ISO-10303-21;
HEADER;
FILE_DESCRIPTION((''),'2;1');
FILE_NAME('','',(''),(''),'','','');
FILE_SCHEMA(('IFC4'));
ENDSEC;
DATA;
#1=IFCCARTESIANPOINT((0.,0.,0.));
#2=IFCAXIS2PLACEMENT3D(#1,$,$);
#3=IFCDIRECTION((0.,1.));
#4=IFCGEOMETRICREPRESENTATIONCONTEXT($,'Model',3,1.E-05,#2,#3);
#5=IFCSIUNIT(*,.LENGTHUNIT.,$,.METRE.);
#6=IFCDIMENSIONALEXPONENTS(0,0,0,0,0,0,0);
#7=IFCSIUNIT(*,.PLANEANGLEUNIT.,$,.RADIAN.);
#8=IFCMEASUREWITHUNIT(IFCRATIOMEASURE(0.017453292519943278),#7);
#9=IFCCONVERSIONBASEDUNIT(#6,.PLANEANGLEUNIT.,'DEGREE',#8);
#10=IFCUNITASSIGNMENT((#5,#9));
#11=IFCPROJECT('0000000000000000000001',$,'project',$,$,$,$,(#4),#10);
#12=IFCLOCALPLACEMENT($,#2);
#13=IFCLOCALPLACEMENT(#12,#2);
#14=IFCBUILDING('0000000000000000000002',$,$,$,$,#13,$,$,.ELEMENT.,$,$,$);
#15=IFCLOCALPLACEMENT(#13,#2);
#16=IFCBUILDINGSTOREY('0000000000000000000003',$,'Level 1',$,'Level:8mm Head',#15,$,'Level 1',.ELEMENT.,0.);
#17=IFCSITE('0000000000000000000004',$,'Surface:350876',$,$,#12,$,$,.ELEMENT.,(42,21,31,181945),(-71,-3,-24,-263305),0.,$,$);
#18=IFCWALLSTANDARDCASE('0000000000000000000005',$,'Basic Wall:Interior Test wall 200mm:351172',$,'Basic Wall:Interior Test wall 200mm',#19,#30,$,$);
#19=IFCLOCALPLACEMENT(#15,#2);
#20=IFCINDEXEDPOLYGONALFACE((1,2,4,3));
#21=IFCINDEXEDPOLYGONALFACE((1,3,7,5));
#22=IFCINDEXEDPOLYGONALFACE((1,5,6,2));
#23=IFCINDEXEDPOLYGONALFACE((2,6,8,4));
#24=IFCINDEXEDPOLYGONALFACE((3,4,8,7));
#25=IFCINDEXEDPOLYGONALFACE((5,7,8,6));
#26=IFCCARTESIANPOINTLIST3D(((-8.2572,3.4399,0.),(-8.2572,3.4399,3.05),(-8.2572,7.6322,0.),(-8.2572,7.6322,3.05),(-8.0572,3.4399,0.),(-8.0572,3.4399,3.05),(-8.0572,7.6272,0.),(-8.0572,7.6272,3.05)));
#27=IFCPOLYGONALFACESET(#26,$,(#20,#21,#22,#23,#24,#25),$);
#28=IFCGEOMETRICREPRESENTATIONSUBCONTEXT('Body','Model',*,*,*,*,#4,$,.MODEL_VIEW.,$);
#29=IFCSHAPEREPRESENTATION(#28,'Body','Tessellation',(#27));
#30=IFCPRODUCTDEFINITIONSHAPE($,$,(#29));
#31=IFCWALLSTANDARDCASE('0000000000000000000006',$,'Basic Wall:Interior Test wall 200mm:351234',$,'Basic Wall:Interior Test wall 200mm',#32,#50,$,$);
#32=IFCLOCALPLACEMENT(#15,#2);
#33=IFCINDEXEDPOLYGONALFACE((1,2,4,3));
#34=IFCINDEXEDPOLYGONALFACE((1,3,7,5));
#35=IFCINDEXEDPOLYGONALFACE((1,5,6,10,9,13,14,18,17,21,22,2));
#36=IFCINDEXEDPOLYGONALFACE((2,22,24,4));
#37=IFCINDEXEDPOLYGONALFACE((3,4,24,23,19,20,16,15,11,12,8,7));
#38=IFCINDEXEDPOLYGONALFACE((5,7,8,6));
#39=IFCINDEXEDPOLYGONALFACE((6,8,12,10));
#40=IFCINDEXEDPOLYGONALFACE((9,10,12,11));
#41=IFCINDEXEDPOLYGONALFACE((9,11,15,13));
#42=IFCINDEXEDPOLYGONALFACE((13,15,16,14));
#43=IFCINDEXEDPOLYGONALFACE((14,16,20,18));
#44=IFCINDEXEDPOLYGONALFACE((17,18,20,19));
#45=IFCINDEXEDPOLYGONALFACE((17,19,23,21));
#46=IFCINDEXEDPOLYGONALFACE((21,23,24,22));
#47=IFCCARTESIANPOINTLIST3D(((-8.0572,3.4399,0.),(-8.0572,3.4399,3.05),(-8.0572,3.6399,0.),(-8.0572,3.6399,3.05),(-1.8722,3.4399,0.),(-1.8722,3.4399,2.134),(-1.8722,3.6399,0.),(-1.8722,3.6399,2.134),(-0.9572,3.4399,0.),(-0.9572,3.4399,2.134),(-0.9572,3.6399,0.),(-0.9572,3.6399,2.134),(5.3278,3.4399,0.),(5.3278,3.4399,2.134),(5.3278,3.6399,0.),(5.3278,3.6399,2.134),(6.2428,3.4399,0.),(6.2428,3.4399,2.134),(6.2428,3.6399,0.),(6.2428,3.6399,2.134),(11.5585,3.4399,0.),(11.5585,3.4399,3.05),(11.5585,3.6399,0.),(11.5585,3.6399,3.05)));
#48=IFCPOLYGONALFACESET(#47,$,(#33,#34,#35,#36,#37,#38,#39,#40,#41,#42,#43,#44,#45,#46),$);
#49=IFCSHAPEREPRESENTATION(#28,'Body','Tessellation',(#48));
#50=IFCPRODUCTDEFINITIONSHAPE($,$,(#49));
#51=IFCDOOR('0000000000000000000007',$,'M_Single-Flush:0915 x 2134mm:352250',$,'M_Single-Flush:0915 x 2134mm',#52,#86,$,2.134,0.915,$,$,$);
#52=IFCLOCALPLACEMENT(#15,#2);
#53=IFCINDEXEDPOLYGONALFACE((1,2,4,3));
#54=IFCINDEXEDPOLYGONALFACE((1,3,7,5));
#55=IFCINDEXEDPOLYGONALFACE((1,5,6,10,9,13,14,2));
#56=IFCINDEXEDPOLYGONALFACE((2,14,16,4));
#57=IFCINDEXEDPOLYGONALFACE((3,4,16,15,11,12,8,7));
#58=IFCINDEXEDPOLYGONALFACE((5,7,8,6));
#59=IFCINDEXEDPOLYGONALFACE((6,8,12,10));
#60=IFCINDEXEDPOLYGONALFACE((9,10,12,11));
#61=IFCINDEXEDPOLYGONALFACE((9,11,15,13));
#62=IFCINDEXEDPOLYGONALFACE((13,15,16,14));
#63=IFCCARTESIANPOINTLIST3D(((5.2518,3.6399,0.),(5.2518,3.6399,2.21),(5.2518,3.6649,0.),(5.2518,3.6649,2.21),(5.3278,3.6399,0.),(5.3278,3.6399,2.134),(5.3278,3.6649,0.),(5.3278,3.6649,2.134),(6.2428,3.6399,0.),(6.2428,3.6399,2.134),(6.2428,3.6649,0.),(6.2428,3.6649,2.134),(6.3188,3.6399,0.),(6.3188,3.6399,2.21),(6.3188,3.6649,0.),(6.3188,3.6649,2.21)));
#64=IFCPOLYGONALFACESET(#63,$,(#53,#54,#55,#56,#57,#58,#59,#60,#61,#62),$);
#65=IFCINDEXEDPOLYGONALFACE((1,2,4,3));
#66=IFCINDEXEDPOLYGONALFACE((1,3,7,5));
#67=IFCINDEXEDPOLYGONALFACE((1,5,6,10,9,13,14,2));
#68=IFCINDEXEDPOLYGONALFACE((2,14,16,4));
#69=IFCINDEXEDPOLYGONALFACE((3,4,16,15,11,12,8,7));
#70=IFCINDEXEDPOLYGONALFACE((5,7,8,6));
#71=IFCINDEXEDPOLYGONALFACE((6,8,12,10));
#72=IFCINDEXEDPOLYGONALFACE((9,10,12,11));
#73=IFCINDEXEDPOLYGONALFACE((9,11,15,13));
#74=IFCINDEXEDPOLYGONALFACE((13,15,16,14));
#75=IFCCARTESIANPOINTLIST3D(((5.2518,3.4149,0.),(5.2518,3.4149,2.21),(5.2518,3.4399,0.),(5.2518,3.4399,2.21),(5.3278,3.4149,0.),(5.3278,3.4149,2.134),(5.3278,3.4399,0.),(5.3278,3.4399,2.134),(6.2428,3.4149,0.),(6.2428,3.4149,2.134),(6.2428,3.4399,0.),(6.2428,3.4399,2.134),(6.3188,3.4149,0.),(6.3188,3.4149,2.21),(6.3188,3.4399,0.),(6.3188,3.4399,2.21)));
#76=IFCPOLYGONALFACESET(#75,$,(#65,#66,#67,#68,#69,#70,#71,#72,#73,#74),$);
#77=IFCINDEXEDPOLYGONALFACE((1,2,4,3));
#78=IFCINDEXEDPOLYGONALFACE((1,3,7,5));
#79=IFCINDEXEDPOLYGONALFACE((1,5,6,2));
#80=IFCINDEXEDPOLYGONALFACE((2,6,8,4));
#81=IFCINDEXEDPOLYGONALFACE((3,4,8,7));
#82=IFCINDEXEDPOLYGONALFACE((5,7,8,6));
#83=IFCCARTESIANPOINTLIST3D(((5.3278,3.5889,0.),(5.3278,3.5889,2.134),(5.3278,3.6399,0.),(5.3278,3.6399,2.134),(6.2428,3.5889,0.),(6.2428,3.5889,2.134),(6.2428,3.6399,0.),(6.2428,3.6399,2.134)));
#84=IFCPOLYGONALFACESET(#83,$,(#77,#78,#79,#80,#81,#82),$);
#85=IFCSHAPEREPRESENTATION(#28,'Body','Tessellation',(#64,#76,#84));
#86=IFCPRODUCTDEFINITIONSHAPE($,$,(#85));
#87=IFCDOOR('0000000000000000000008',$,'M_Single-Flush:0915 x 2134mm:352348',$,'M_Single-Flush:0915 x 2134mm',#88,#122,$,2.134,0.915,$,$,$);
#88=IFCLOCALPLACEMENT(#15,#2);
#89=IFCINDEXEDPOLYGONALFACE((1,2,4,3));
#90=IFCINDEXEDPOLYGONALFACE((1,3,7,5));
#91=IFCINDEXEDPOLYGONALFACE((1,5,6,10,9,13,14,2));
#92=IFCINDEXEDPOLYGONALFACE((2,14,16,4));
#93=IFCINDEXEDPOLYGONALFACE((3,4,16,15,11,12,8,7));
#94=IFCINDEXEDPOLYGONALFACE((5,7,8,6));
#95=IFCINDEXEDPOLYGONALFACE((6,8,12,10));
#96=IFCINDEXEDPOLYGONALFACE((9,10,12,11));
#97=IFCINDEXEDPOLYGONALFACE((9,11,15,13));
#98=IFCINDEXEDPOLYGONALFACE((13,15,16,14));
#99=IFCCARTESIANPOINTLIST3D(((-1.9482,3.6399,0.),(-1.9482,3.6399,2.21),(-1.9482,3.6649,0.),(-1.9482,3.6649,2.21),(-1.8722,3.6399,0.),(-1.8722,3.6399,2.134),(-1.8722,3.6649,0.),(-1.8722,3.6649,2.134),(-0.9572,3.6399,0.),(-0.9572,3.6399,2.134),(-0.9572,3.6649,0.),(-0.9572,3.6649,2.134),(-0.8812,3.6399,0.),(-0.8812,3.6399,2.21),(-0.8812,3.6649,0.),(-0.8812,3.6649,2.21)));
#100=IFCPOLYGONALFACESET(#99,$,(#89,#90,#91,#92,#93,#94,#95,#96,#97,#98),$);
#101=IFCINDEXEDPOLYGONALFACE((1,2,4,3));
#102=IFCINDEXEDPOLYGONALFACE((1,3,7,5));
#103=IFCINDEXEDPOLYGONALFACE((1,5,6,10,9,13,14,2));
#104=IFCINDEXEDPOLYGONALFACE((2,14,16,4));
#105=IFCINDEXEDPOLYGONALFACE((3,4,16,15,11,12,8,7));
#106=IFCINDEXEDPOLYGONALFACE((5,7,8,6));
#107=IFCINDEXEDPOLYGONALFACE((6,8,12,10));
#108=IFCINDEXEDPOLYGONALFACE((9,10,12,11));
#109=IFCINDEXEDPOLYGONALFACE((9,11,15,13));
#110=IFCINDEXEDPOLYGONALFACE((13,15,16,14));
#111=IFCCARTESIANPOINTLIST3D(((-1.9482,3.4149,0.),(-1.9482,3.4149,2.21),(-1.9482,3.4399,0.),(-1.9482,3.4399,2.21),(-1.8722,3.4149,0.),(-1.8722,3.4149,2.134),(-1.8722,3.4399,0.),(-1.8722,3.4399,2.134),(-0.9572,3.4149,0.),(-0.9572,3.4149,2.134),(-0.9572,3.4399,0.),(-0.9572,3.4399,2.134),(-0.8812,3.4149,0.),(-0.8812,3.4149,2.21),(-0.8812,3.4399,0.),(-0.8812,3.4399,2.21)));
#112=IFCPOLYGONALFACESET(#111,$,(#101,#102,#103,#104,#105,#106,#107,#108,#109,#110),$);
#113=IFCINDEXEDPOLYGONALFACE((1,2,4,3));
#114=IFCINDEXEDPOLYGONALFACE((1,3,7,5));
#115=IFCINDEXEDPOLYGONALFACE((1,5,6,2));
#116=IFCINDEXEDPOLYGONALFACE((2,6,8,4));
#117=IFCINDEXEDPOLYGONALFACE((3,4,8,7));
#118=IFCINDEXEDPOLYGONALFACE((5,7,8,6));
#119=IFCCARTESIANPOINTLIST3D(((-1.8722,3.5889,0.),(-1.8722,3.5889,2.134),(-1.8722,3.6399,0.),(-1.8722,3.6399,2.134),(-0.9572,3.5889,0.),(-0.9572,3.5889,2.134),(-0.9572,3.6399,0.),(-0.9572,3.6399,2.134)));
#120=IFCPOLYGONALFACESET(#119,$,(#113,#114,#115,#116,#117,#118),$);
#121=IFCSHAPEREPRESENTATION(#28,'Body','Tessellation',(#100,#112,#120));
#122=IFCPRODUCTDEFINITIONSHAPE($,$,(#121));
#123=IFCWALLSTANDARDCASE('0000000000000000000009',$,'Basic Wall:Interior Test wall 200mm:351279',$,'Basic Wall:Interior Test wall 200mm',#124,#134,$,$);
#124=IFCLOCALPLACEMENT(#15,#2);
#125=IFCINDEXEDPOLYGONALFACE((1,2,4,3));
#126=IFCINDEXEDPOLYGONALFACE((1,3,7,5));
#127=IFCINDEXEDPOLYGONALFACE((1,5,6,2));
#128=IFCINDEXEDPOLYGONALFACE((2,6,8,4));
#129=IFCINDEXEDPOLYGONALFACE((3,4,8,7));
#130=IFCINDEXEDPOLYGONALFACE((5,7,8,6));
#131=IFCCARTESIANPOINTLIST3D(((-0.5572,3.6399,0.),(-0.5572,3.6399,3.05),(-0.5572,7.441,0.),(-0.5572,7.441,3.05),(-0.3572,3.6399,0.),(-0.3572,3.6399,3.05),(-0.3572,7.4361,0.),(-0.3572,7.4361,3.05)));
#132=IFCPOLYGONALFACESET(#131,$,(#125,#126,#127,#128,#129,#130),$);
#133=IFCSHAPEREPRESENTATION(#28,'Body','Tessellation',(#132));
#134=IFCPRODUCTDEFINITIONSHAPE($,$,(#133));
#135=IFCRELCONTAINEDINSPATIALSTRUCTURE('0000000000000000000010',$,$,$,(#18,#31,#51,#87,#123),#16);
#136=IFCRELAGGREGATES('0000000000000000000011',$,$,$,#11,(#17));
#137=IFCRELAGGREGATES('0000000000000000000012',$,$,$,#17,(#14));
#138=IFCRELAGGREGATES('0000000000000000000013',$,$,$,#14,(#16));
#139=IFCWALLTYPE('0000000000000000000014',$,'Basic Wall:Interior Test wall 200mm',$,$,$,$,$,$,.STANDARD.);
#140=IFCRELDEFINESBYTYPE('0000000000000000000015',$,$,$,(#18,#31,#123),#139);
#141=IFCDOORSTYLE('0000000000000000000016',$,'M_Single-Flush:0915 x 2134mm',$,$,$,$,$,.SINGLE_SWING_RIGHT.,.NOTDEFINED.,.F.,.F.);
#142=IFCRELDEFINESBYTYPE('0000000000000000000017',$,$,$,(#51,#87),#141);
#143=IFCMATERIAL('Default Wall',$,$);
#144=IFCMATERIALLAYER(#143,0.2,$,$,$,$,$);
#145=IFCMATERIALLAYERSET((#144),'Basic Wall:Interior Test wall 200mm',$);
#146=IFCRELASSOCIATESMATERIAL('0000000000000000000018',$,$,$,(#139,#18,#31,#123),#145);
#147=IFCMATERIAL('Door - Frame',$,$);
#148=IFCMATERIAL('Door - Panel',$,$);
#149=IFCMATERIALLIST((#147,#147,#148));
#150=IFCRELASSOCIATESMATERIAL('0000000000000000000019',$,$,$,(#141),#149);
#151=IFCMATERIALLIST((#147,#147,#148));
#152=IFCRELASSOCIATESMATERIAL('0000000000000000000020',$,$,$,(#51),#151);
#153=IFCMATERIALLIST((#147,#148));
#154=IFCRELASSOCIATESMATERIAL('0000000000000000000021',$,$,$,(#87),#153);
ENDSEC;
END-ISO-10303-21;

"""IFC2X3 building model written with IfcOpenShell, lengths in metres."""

from ifc_helpers import new_model, entity, si_unit, converted_unit, direction, frame, frame_2d, origin, place, context, subcontext, project, spatial, polyline, rectangle, outline, extrude, clip, bounded_halfspace, source, transform, mapped, material, material_list, layer, layer_set, layer_usage, type_object, type_shapes, element, fill, save


model = new_model("IFC2X3")

# Units and contexts
model_context = context("Model", 3, precision=1e-05, world=origin(), true_north=direction((0.0, 1.0)))
body_context = subcontext(model_context, "Body", "Model", "MODEL_VIEW")
ifc_project = project(units=[si_unit("LENGTHUNIT", "METRE"), converted_unit("PLANEANGLEUNIT", "DEGREE", entity("IfcRatioMeasure", 0.017453292519943278), si_unit("PLANEANGLEUNIT", "RADIAN"), dimensions=[0, 0, 0, 0, 0, 0, 0])], contexts=[model_context])

# Site, building, storey
site_placement = place(None, origin())
site = spatial("IfcSite", under=ifc_project, at=site_placement, Name="Surface:350876", CompositionType="ELEMENT", RefLatitude=(42, 21, 31, 181945), RefLongitude=(-71, -3, -24, -263305), RefElevation=0.0)
building_placement = place(site_placement, origin())
building = spatial("IfcBuilding", under=site, at=building_placement, CompositionType="ELEMENT")
storey_placement = place(building_placement, origin())
storey = spatial("IfcBuildingStorey", under=building, at=storey_placement, Name="Level 1", ObjectType="Level:8mm Head", LongName="Level 1", CompositionType="ELEMENT", Elevation=0.0)

# Shared definitions
ifc_material_1 = material(Name="Default Wall")

# Wall
ifc_layer_1 = layer(ifc_material_1, 0.2)
ifc_layer_set_1 = layer_set([ifc_layer_1], Name="Basic Wall:Interior Test wall 200mm")
ifc_layer_usage_1 = layer_usage(ifc_layer_set_1, "AXIS2", "NEGATIVE", 0.1)
wall_type_1 = type_object("IfcWallType", Name="Basic Wall:Interior Test wall 200mm", PredefinedType="STANDARD", material=ifc_layer_set_1)
wall_1_placement = place(storey_placement, frame((-8.1572, 7.6322, 0.0), z_axis=(0.0, 0.0, 1.0), x_axis=(0.0, -1.0, 0.0)))
element("IfcWallStandardCase", 1, at=wall_1_placement, inside=storey, type_object=wall_type_1, material=ifc_layer_usage_1, Name="Basic Wall:Interior Test wall 200mm:351172", ObjectType="Basic Wall:Interior Test wall 200mm", context=body_context, shape_type="Clipping", body=[
    clip(extrude(outline(polyline([(4.1922, -0.1), (4.1922, 0.1), (3.9922, 0.1), (0.005, 0.1), (0.0, -0.1), (4.1922, -0.1)])), origin(), (0.0, 0.0, 1.0), 3.05), bounded_halfspace(frame((0.0, -0.1, 3.05), z_axis=(0.0, 0.0, -1.0), x_axis=(-0.97437, 0.224951, 0.0)), True, frame((0.0, -0.1, 3.05)), polyline([(0.0, 0.0), (0.2922, 0.0), (4.1922, 0.0), (4.1922, 0.2), (3.9922, 0.2), (0.005, 0.2), (0.0, 0.0)]))),
])

# Wall, openings, doors
ifc_layer_usage_2 = layer_usage(ifc_layer_set_1, "AXIS2", "NEGATIVE", 0.1)
wall_2_placement = place(storey_placement, frame((-8.0572, 3.5399, 0.0)))
wall_2 = element("IfcWallStandardCase", 2, at=wall_2_placement, inside=storey, type_object=wall_type_1, material=ifc_layer_usage_2, Name="Basic Wall:Interior Test wall 200mm:351234", ObjectType="Basic Wall:Interior Test wall 200mm", context=body_context, shape_type="Clipping", body=[
    clip(extrude(rectangle(XDim=19.6158, YDim=0.2, at=frame_2d((9.8079, 0.0), x_axis=(-1.0, 0.0))), origin(), (0.0, 0.0, 1.0), 3.05), bounded_halfspace(frame((0.0, -0.1, 3.05), z_axis=(0.0, 0.0, -1.0), x_axis=(0.224951, 0.97437, 0.0)), True, frame((0.0, -0.1, 3.05)), polyline([(0.0, 0.0), (19.6158, 0.0), (19.6158, 0.2), (15.2, 0.2), (15.0, 0.2), (7.7, 0.2), (7.5, 0.2), (0.0, 0.2), (0.0, 0.0)]))),
])
opening_1_placement = place(wall_2_placement, frame((13.385, -0.1, 0.0)))
opening_1 = element("IfcOpeningElement", 3, at=opening_1_placement, cuts=wall_2, ObjectType="Opening", context=body_context, shape_type="SweptSolid", body=[
    extrude(rectangle(XDim=0.915, YDim=2.134, at=frame_2d((1.067, 0.4575), x_axis=(0.0, 1.0))), frame((0.0, 0.0, 0.0), z_axis=(0.0, 1.0, 0.0), x_axis=(0.0, 0.0, 1.0)), (0.0, 0.0, 1.0), 0.2),
])
opening_2_placement = place(wall_2_placement, frame((6.185, -0.1, 0.0)))
opening_2 = element("IfcOpeningElement", 4, at=opening_2_placement, cuts=wall_2, ObjectType="Opening", context=body_context, shape_type="SweptSolid", body=[
    extrude(rectangle(XDim=0.915, YDim=2.134, at=frame_2d((1.067, 0.4575), x_axis=(0.0, 1.0))), frame((0.0, 0.0, 0.0), z_axis=(0.0, 1.0, 0.0), x_axis=(0.0, 0.0, 1.0)), (0.0, 0.0, 1.0), 0.2),
])
ifc_material_2 = material(Name="Door - Frame")
ifc_material_3 = material(Name="Door - Panel")
ifc_material_list_1 = material_list([ifc_material_2, ifc_material_2, ifc_material_3])
ifc_material_list_2 = material_list([ifc_material_2, ifc_material_2, ifc_material_3])
door_style_1 = type_object("IfcDoorStyle", Name="M_Single-Flush:0915 x 2134mm", ConstructionType="NOTDEFINED", OperationType="SINGLE_SWING_RIGHT", ParameterTakesPrecedence=False, Sizeable=False, material=ifc_material_list_2)
shared_shape_1 = source(origin(), body_context, "Body", "SweptSolid", [
    extrude(outline(polyline([(-0.5335, -1.124), (0.5335, -1.124), (0.5335, 1.086), (0.4575, 1.086), (0.4575, -1.048), (-0.4575, -1.048), (-0.4575, 1.086), (-0.5335, 1.086), (-0.5335, -1.124)])), frame((0.4575, 0.2, 1.086), z_axis=(0.0, 1.0, 0.0), x_axis=(1.0, 0.0, 0.0)), (0.0, 0.0, 1.0), 0.025),
    extrude(outline(polyline([(-1.124, -0.5335), (1.086, -0.5335), (1.086, -0.4575), (-1.048, -0.4575), (-1.048, 0.4575), (1.086, 0.4575), (1.086, 0.5335), (-1.124, 0.5335), (-1.124, -0.5335)])), frame((0.4575, -0.025, 1.086), z_axis=(0.0, 1.0, 0.0), x_axis=(0.0, 0.0, -1.0)), (0.0, 0.0, 1.0), 0.025),
    extrude(rectangle(XDim=0.051, YDim=0.915, at=frame_2d((0.0, 0.0), x_axis=(1.0, 0.0))), frame((0.4575, 0.1745, 0.0), z_axis=(0.0, 0.0, 1.0), x_axis=(0.0, 1.0, 0.0)), (0.0, 0.0, 1.0), 2.134),
])
type_shapes(door_style_1, [shared_shape_1])
door_1_placement = place(opening_1_placement, origin())
door_1 = element("IfcDoor", 5, at=door_1_placement, inside=storey, type_object=door_style_1, material=ifc_material_list_1, Name="M_Single-Flush:0915 x 2134mm:352250", ObjectType="M_Single-Flush:0915 x 2134mm", OverallHeight=2.134, OverallWidth=0.915, context=body_context, shape_type="MappedRepresentation", body=[
    mapped(shared_shape_1, transform((0.0, 0.0, 0.0), scale=1.0)),
])
fill(opening_1, door_1)
ifc_material_list_3 = material_list([ifc_material_2, ifc_material_3])
door_2_placement = place(opening_2_placement, origin())
door_2 = element("IfcDoor", 6, at=door_2_placement, inside=storey, type_object=door_style_1, material=ifc_material_list_3, Name="M_Single-Flush:0915 x 2134mm:352348", ObjectType="M_Single-Flush:0915 x 2134mm", OverallHeight=2.134, OverallWidth=0.915, context=body_context, shape_type="MappedRepresentation", body=[
    mapped(shared_shape_1, transform((0.0, 0.0, 0.0), scale=1.0)),
])
fill(opening_2, door_2)

# Wall
ifc_layer_usage_3 = layer_usage(ifc_layer_set_1, "AXIS2", "NEGATIVE", 0.1)
wall_3_placement = place(storey_placement, frame((-0.4572, 3.6399, 0.0), z_axis=(0.0, 0.0, 1.0), x_axis=(0.0, 1.0, 0.0)))
element("IfcWallStandardCase", 7, at=wall_3_placement, inside=storey, type_object=wall_type_1, material=ifc_layer_usage_3, Name="Basic Wall:Interior Test wall 200mm:351279", ObjectType="Basic Wall:Interior Test wall 200mm", context=body_context, shape_type="Clipping", body=[
    clip(extrude(outline(polyline([(3.7961, -0.1), (3.8011, 0.1), (0.0, 0.1), (0.0, -0.1), (3.7961, -0.1)])), origin(), (0.0, 0.0, 1.0), 3.05), bounded_halfspace(frame((0.0, -0.1, 3.05), z_axis=(0.0, 0.0, -1.0), x_axis=(0.97437, -0.224951, 0.0)), True, frame((0.0, -0.1, 3.05)), polyline([(0.0, 0.0), (3.7961, 0.0), (3.8011, 0.2), (0.0, 0.2), (0.0, 0.0)]))),
])

save(model, "model.ifc")
